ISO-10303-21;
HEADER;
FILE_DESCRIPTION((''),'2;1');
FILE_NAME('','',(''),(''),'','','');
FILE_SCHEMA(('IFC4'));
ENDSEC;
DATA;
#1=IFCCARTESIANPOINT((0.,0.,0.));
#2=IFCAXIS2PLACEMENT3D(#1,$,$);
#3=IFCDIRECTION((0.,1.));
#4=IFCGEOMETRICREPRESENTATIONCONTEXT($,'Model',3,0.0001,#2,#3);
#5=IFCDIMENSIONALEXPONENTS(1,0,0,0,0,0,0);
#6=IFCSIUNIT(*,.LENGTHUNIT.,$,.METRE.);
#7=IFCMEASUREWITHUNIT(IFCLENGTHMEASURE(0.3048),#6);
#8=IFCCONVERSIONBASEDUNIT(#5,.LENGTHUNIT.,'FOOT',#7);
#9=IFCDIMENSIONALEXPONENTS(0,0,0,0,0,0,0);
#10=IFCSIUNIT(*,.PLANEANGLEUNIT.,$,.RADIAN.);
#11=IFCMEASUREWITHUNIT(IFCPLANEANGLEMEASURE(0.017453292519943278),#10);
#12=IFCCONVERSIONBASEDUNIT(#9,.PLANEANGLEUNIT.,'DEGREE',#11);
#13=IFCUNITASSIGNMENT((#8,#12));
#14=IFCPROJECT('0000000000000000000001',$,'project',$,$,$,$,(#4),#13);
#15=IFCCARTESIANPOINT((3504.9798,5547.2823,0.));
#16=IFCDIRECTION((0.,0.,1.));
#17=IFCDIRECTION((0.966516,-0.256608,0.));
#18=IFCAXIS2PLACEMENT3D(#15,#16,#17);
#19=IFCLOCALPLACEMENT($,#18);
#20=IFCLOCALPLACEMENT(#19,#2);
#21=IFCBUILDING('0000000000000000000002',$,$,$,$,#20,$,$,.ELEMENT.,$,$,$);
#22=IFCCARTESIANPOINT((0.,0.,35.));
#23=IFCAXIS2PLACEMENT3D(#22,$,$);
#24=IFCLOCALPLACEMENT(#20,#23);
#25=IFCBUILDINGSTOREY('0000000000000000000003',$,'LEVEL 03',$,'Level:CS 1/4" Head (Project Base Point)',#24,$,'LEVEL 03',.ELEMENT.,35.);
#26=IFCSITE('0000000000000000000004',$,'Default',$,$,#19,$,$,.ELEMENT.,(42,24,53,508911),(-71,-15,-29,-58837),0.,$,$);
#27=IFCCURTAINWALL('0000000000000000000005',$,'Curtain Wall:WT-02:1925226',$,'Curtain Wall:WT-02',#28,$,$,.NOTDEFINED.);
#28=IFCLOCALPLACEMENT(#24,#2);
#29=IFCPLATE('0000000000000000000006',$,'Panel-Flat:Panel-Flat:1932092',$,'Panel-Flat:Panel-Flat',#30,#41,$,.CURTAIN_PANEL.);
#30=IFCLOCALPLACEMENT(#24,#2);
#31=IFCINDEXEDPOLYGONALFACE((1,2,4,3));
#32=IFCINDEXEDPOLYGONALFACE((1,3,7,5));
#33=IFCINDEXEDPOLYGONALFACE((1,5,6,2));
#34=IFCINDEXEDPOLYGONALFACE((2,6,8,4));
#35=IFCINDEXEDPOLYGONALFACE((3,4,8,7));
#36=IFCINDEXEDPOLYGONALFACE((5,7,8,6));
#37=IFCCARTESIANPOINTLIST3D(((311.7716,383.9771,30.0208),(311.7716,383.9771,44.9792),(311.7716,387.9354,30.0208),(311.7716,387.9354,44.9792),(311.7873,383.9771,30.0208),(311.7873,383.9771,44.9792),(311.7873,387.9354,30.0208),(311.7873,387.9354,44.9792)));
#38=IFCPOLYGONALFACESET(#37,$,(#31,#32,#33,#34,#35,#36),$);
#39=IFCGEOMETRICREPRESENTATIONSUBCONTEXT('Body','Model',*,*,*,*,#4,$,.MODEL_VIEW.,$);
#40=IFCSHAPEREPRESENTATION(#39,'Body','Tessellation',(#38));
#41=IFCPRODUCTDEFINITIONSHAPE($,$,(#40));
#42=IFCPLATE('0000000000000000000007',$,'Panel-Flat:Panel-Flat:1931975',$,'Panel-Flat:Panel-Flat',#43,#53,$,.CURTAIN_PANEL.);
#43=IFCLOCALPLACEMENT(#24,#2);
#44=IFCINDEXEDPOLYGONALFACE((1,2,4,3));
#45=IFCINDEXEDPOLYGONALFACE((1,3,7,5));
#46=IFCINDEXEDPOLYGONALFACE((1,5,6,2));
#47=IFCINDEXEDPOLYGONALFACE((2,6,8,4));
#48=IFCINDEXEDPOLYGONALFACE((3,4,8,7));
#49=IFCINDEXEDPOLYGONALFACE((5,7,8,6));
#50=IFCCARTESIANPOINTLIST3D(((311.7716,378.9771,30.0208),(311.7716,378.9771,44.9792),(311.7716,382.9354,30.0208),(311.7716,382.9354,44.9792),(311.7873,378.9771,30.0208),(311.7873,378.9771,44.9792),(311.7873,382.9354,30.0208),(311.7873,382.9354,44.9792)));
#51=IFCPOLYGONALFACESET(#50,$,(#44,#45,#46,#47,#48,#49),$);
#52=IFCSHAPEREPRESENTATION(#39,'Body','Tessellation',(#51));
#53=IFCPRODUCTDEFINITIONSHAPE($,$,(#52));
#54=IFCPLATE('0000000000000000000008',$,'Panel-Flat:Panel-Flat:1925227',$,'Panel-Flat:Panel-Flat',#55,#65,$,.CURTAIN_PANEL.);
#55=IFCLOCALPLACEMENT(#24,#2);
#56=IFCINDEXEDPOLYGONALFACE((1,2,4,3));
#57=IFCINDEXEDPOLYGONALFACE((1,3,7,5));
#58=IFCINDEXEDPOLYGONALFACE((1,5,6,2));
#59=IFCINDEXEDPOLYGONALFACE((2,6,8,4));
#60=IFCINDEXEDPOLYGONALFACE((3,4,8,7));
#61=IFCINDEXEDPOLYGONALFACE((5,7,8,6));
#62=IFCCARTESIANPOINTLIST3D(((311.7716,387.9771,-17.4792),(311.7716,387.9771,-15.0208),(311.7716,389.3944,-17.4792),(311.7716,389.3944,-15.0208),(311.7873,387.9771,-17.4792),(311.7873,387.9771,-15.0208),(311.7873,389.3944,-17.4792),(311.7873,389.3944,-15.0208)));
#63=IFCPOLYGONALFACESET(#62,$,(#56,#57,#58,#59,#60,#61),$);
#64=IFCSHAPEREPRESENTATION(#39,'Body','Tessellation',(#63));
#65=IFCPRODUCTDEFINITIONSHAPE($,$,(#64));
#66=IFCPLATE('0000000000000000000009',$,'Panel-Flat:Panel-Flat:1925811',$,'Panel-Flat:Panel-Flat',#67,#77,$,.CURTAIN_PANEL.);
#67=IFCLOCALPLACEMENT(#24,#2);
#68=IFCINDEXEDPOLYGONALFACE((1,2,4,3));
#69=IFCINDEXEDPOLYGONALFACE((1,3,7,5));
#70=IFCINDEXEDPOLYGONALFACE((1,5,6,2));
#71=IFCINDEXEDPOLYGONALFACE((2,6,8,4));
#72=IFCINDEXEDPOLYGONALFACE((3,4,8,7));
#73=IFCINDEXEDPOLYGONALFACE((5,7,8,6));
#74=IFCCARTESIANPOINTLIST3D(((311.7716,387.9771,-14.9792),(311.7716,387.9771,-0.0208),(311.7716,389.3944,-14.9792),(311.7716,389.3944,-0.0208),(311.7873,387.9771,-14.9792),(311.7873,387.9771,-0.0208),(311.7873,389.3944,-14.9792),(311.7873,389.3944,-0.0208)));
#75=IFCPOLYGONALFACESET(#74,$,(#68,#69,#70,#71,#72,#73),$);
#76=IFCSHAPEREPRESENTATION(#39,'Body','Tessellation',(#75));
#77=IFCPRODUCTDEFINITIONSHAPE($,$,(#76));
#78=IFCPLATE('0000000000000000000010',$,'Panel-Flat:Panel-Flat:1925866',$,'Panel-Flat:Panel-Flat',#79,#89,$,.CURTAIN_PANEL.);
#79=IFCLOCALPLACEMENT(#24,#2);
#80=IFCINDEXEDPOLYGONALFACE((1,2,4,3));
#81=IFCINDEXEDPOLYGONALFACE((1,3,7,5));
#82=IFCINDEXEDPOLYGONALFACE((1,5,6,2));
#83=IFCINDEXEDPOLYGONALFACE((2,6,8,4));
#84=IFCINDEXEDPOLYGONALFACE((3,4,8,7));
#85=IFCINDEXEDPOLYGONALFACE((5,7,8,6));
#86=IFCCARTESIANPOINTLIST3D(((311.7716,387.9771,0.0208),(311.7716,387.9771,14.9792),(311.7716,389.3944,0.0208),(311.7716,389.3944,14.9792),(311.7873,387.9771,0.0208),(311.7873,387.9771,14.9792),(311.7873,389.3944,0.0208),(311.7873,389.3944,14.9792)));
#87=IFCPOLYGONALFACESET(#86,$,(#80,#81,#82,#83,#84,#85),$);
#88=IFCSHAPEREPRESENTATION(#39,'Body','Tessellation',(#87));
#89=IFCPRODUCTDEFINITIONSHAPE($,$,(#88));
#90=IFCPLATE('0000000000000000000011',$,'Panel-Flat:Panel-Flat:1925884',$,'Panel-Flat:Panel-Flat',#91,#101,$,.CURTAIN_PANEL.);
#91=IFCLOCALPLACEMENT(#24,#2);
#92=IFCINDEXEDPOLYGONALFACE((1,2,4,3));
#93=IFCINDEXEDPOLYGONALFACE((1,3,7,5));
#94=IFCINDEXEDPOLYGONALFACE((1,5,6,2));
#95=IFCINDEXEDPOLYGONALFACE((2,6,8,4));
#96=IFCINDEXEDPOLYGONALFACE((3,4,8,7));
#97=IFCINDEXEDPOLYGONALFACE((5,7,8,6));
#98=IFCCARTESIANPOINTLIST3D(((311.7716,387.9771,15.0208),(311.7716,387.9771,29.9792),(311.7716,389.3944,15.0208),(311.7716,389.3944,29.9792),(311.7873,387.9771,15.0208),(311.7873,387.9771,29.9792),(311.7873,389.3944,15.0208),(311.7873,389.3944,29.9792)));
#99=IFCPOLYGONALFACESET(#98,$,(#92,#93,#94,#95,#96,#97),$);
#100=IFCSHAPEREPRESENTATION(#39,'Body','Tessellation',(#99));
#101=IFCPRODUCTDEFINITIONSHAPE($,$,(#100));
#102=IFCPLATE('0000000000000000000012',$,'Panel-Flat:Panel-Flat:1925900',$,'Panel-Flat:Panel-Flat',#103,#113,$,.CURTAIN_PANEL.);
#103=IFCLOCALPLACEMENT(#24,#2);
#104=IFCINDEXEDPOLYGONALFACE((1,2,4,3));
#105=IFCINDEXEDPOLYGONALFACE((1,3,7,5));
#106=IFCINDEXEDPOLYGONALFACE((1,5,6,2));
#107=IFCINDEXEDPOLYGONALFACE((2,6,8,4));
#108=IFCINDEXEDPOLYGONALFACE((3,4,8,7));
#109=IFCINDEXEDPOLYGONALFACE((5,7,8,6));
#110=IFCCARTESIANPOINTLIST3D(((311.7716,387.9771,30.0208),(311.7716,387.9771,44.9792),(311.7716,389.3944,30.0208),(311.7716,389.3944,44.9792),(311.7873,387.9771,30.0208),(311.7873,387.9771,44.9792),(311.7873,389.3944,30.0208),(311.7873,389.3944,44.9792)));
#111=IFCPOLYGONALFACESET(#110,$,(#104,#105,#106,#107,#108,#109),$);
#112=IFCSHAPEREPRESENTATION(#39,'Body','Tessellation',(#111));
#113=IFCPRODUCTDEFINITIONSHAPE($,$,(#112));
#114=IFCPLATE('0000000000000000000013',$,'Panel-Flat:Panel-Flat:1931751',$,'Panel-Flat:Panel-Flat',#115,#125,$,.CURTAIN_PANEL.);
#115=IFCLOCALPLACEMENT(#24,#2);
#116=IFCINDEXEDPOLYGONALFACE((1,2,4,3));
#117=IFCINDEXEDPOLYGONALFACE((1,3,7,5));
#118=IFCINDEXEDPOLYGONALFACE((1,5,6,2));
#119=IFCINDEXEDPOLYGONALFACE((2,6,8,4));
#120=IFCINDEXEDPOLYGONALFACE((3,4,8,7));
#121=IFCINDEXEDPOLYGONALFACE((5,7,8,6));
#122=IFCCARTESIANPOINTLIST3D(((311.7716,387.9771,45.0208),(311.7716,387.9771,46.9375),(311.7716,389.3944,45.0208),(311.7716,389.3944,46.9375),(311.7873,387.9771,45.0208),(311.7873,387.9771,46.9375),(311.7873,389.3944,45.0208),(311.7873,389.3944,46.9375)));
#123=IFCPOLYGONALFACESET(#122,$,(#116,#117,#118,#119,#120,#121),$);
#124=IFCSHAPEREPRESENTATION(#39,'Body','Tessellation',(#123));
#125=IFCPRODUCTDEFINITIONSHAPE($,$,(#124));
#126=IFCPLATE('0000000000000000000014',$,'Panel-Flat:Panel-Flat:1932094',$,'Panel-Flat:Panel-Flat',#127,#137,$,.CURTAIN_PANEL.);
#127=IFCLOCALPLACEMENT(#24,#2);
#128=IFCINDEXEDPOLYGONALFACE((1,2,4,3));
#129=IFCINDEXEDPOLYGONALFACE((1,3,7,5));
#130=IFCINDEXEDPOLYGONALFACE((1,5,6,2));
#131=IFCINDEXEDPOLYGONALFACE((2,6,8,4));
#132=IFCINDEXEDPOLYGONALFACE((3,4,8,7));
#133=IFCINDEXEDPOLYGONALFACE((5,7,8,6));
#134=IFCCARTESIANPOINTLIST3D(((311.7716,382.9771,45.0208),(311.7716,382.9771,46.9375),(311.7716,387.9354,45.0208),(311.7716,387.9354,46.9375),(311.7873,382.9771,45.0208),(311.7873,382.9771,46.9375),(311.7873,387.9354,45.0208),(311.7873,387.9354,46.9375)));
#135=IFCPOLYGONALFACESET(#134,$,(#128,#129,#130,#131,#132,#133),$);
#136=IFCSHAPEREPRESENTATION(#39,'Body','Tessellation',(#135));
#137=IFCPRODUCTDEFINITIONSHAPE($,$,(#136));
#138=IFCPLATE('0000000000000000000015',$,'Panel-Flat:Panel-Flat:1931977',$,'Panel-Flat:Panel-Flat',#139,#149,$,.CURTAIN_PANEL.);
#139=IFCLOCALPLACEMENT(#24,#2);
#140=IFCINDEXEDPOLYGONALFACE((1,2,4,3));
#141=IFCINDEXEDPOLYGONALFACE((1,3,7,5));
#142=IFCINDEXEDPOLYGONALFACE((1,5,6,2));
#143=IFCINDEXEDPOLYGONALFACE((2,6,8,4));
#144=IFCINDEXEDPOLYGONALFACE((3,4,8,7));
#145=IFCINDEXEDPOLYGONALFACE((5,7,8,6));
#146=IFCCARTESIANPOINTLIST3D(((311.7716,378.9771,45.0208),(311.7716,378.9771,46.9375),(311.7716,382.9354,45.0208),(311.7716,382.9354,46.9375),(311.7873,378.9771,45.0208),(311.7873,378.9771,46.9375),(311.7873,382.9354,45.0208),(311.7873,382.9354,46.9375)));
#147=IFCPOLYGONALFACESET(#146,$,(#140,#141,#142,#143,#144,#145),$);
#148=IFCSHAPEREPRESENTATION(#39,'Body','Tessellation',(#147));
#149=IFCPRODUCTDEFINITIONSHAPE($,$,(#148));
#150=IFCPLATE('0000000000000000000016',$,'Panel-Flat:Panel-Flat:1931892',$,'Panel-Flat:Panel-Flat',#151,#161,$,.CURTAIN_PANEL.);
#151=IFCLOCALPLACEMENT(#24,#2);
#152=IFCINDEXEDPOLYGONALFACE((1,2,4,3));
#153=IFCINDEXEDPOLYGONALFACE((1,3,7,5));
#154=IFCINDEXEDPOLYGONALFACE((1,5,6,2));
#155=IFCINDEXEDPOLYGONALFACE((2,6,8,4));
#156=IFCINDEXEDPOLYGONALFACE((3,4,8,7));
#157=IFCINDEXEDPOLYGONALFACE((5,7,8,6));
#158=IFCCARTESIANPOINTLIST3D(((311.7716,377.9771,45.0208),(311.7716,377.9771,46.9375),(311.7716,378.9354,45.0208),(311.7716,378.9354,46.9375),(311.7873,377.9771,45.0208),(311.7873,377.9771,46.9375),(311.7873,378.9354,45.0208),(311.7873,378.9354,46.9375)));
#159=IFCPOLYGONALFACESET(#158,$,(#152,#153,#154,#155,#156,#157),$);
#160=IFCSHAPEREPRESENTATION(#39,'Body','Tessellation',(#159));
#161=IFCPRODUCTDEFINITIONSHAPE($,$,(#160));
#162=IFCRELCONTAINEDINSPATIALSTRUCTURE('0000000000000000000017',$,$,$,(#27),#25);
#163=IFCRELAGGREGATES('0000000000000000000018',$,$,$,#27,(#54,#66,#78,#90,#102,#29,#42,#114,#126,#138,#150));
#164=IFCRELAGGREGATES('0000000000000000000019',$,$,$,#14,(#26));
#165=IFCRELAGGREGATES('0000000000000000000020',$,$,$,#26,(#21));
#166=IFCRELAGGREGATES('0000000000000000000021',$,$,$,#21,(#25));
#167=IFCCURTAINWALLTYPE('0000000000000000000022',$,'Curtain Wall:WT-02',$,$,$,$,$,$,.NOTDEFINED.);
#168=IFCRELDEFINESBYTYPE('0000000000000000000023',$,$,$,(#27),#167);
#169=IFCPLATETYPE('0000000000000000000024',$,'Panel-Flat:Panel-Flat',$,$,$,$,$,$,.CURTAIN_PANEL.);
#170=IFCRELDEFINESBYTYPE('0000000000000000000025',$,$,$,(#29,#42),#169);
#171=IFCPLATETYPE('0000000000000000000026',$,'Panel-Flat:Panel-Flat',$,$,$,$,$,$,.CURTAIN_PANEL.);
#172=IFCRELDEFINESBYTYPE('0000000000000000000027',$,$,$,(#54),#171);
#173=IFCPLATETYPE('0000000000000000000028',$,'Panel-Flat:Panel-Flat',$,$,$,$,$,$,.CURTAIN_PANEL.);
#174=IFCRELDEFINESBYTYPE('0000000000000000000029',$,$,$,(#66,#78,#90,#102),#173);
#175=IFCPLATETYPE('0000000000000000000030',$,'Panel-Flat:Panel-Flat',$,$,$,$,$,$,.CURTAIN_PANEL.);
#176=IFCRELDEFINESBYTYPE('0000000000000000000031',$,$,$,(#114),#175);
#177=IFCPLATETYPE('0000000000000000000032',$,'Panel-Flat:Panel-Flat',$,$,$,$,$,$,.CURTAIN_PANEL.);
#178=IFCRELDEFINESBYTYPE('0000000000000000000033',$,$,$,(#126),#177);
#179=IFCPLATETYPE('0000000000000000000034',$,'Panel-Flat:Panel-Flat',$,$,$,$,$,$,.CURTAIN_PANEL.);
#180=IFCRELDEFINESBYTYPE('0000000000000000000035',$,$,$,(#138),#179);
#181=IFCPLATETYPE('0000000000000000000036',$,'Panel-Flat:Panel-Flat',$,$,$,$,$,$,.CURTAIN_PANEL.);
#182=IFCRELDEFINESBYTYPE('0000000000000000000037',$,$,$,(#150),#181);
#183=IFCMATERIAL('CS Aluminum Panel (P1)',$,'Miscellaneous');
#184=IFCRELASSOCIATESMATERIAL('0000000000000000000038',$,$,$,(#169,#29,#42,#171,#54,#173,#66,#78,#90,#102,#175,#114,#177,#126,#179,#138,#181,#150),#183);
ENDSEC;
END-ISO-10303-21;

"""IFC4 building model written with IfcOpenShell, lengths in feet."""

from ifc_helpers import new_model, entity, si_unit, converted_unit, direction, frame, origin, place, context, subcontext, project, spatial, indexed_curve, outline, extrude, source, transform, mapped, material, type_object, type_shapes, element, aggregate, save


model = new_model("IFC4")

# Units and contexts
model_context = context("Model", 3, precision=0.0001, world=origin(), true_north=direction((0.0, 1.0)))
body_context = subcontext(model_context, "Body", "Model", "MODEL_VIEW")
ifc_project = project(units=[converted_unit("LENGTHUNIT", "FOOT", entity("IfcLengthMeasure", 0.3048), si_unit("LENGTHUNIT", "METRE"), dimensions=[1, 0, 0, 0, 0, 0, 0]), converted_unit("PLANEANGLEUNIT", "DEGREE", entity("IfcPlaneAngleMeasure", 0.017453292519943278), si_unit("PLANEANGLEUNIT", "RADIAN"), dimensions=[0, 0, 0, 0, 0, 0, 0])], contexts=[model_context])

# Site, building, storey
site_placement = place(None, frame((3504.9798, 5547.2823, 0.0), z_axis=(0.0, 0.0, 1.0), x_axis=(0.966516, -0.256608, 0.0)))
site = spatial("IfcSite", under=ifc_project, at=site_placement, Name="Default", CompositionType="ELEMENT", RefLatitude=(42, 24, 53, 508911), RefLongitude=(-71, -15, -29, -58837), RefElevation=0.0)
building_placement = place(site_placement, origin())
building = spatial("IfcBuilding", under=site, at=building_placement, CompositionType="ELEMENT")
storey_placement = place(building_placement, frame((0.0, 0.0, 35.0)))
storey = spatial("IfcBuildingStorey", under=building, at=storey_placement, Name="LEVEL 03", ObjectType="Level:CS 1/4\" Head (Project Base Point)", LongName="LEVEL 03", CompositionType="ELEMENT", Elevation=35.0)

# Curtain wall, plates
curtain_wall_type = type_object("IfcCurtainWallType", Name="Curtain Wall:WT-02", PredefinedType="NOTDEFINED")
curtain_wall_1_placement = place(storey_placement, frame((0.0, 0.0, -35.0)))
curtain_wall_1 = element("IfcCurtainWall", 1, at=curtain_wall_1_placement, inside=storey, type_object=curtain_wall_type, Name="Curtain Wall:WT-02:1925226", ObjectType="Curtain Wall:WT-02", PredefinedType="NOTDEFINED")
ifc_material_1 = material(Name="CS Aluminum Panel (P1)", Category="Miscellaneous")
plate_type_1 = type_object("IfcPlateType", Name="Panel-Flat:Panel-Flat", PredefinedType="CURTAIN_PANEL", material=ifc_material_1)
shared_shape_1 = source(origin(), body_context, "Body", "SweptSolid", [
    extrude(outline(indexed_curve([(-0.0078, -1.9792), (0.0078, -1.9792), (0.0078, 1.9792), (-0.0078, 1.9792), (-0.0078, -1.9792)], self_intersect=False)), frame((0.0, -0.0078, 0.0208), z_axis=(0.0, 0.0, 1.0), x_axis=(0.0, -1.0, 0.0)), (0.0, 0.0, 1.0), 14.9583),
])
type_shapes(plate_type_1, [shared_shape_1])
plate_1_placement = place(curtain_wall_1_placement, frame((311.7873, 385.9563, 65.0), z_axis=(0.0, 0.0, 1.0), x_axis=(0.0, -1.0, 0.0)))
plate_1 = element("IfcPlate", 2, at=plate_1_placement, type_object=plate_type_1, material=ifc_material_1, Name="Panel-Flat:Panel-Flat:1932092", ObjectType="Panel-Flat:Panel-Flat", PredefinedType="CURTAIN_PANEL", context=body_context, shape_type="MappedRepresentation", body=[
    mapped(shared_shape_1, transform((0.0, 0.0, 0.0), scale=1.0)),
])
plate_2_placement = place(curtain_wall_1_placement, frame((311.7873, 380.9563, 65.0), z_axis=(0.0, 0.0, 1.0), x_axis=(0.0, -1.0, 0.0)))
plate_2 = element("IfcPlate", 3, at=plate_2_placement, type_object=plate_type_1, material=ifc_material_1, Name="Panel-Flat:Panel-Flat:1931975", ObjectType="Panel-Flat:Panel-Flat", PredefinedType="CURTAIN_PANEL", context=body_context, shape_type="MappedRepresentation", body=[
    mapped(shared_shape_1, transform((0.0, 0.0, 0.0), scale=1.0)),
])
plate_type_2 = type_object("IfcPlateType", Name="Panel-Flat:Panel-Flat", PredefinedType="CURTAIN_PANEL", material=ifc_material_1)
shared_shape_2 = source(origin(), body_context, "Body", "SweptSolid", [
    extrude(outline(indexed_curve([(-0.0078, -0.7087), (0.0078, -0.7087), (0.0078, 0.7087), (-0.0078, 0.7087), (-0.0078, -0.7087)], self_intersect=False)), frame((0.0, -0.0078, 0.0208), z_axis=(0.0, 0.0, 1.0), x_axis=(0.0, -1.0, 0.0)), (0.0, 0.0, 1.0), 2.4583),
])
type_shapes(plate_type_2, [shared_shape_2])
plate_3_placement = place(curtain_wall_1_placement, frame((311.7873, 388.6858, 17.5), z_axis=(0.0, 0.0, 1.0), x_axis=(0.0, -1.0, 0.0)))
plate_3 = element("IfcPlate", 4, at=plate_3_placement, type_object=plate_type_2, material=ifc_material_1, Name="Panel-Flat:Panel-Flat:1925227", ObjectType="Panel-Flat:Panel-Flat", PredefinedType="CURTAIN_PANEL", context=body_context, shape_type="MappedRepresentation", body=[
    mapped(shared_shape_2, transform((0.0, 0.0, 0.0), scale=1.0)),
])
plate_type_3 = type_object("IfcPlateType", Name="Panel-Flat:Panel-Flat", PredefinedType="CURTAIN_PANEL", material=ifc_material_1)
shared_shape_3 = source(origin(), body_context, "Body", "SweptSolid", [
    extrude(outline(indexed_curve([(-0.0078, -0.7087), (0.0078, -0.7087), (0.0078, 0.7087), (-0.0078, 0.7087), (-0.0078, -0.7087)], self_intersect=False)), frame((0.0, -0.0078, 0.0208), z_axis=(0.0, 0.0, 1.0), x_axis=(0.0, -1.0, 0.0)), (0.0, 0.0, 1.0), 14.9583),
])
type_shapes(plate_type_3, [shared_shape_3])
plate_4_placement = place(curtain_wall_1_placement, frame((311.7873, 388.6858, 20.0), z_axis=(0.0, 0.0, 1.0), x_axis=(0.0, -1.0, 0.0)))
plate_4 = element("IfcPlate", 5, at=plate_4_placement, type_object=plate_type_3, material=ifc_material_1, Name="Panel-Flat:Panel-Flat:1925811", ObjectType="Panel-Flat:Panel-Flat", PredefinedType="CURTAIN_PANEL", context=body_context, shape_type="MappedRepresentation", body=[
    mapped(shared_shape_3, transform((0.0, 0.0, 0.0), scale=1.0)),
])
plate_5_placement = place(curtain_wall_1_placement, frame((311.7873, 388.6858, 35.0), z_axis=(0.0, 0.0, 1.0), x_axis=(0.0, -1.0, 0.0)))
plate_5 = element("IfcPlate", 6, at=plate_5_placement, type_object=plate_type_3, material=ifc_material_1, Name="Panel-Flat:Panel-Flat:1925866", ObjectType="Panel-Flat:Panel-Flat", PredefinedType="CURTAIN_PANEL", context=body_context, shape_type="MappedRepresentation", body=[
    mapped(shared_shape_3, transform((0.0, 0.0, 0.0), scale=1.0)),
])
plate_6_placement = place(curtain_wall_1_placement, frame((311.7873, 388.6858, 50.0), z_axis=(0.0, 0.0, 1.0), x_axis=(0.0, -1.0, 0.0)))
plate_6 = element("IfcPlate", 7, at=plate_6_placement, type_object=plate_type_3, material=ifc_material_1, Name="Panel-Flat:Panel-Flat:1925884", ObjectType="Panel-Flat:Panel-Flat", PredefinedType="CURTAIN_PANEL", context=body_context, shape_type="MappedRepresentation", body=[
    mapped(shared_shape_3, transform((0.0, 0.0, 0.0), scale=1.0)),
])
plate_7_placement = place(curtain_wall_1_placement, frame((311.7873, 388.6858, 65.0), z_axis=(0.0, 0.0, 1.0), x_axis=(0.0, -1.0, 0.0)))
plate_7 = element("IfcPlate", 8, at=plate_7_placement, type_object=plate_type_3, material=ifc_material_1, Name="Panel-Flat:Panel-Flat:1925900", ObjectType="Panel-Flat:Panel-Flat", PredefinedType="CURTAIN_PANEL", context=body_context, shape_type="MappedRepresentation", body=[
    mapped(shared_shape_3, transform((0.0, 0.0, 0.0), scale=1.0)),
])
plate_type_4 = type_object("IfcPlateType", Name="Panel-Flat:Panel-Flat", PredefinedType="CURTAIN_PANEL", material=ifc_material_1)
shared_shape_4 = source(origin(), body_context, "Body", "SweptSolid", [
    extrude(outline(indexed_curve([(-0.0078, -0.7087), (0.0078, -0.7087), (0.0078, 0.7087), (-0.0078, 0.7087), (-0.0078, -0.7087)], self_intersect=False)), frame((0.0, -0.0078, 0.0208), z_axis=(0.0, 0.0, 1.0), x_axis=(0.0, -1.0, 0.0)), (0.0, 0.0, 1.0), 1.9167),
])
type_shapes(plate_type_4, [shared_shape_4])
plate_8_placement = place(curtain_wall_1_placement, frame((311.7873, 388.6858, 80.0), z_axis=(0.0, 0.0, 1.0), x_axis=(0.0, -1.0, 0.0)))
plate_8 = element("IfcPlate", 9, at=plate_8_placement, type_object=plate_type_4, material=ifc_material_1, Name="Panel-Flat:Panel-Flat:1931751", ObjectType="Panel-Flat:Panel-Flat", PredefinedType="CURTAIN_PANEL", context=body_context, shape_type="MappedRepresentation", body=[
    mapped(shared_shape_4, transform((0.0, 0.0, 0.0), scale=1.0)),
])
plate_type_5 = type_object("IfcPlateType", Name="Panel-Flat:Panel-Flat", PredefinedType="CURTAIN_PANEL", material=ifc_material_1)
shared_shape_5 = source(origin(), body_context, "Body", "SweptSolid", [
    extrude(outline(indexed_curve([(-0.0078, -2.4792), (0.0078, -2.4792), (0.0078, 2.4792), (-0.0078, 2.4792), (-0.0078, -2.4792)], self_intersect=False)), frame((0.0, -0.0078, 0.0208), z_axis=(0.0, 0.0, 1.0), x_axis=(0.0, -1.0, 0.0)), (0.0, 0.0, 1.0), 1.9167),
])
type_shapes(plate_type_5, [shared_shape_5])
plate_9_placement = place(curtain_wall_1_placement, frame((311.7873, 385.4563, 80.0), z_axis=(0.0, 0.0, 1.0), x_axis=(0.0, -1.0, 0.0)))
plate_9 = element("IfcPlate", 10, at=plate_9_placement, type_object=plate_type_5, material=ifc_material_1, Name="Panel-Flat:Panel-Flat:1932094", ObjectType="Panel-Flat:Panel-Flat", PredefinedType="CURTAIN_PANEL", context=body_context, shape_type="MappedRepresentation", body=[
    mapped(shared_shape_5, transform((0.0, 0.0, 0.0), scale=1.0)),
])
plate_type_6 = type_object("IfcPlateType", Name="Panel-Flat:Panel-Flat", PredefinedType="CURTAIN_PANEL", material=ifc_material_1)
shared_shape_6 = source(origin(), body_context, "Body", "SweptSolid", [
    extrude(outline(indexed_curve([(-0.0078, -1.9792), (0.0078, -1.9792), (0.0078, 1.9792), (-0.0078, 1.9792), (-0.0078, -1.9792)], self_intersect=False)), frame((0.0, -0.0078, 0.0208), z_axis=(0.0, 0.0, 1.0), x_axis=(0.0, -1.0, 0.0)), (0.0, 0.0, 1.0), 1.9167),
])
type_shapes(plate_type_6, [shared_shape_6])
plate_10_placement = place(curtain_wall_1_placement, frame((311.7873, 380.9563, 80.0), z_axis=(0.0, 0.0, 1.0), x_axis=(0.0, -1.0, 0.0)))
plate_10 = element("IfcPlate", 11, at=plate_10_placement, type_object=plate_type_6, material=ifc_material_1, Name="Panel-Flat:Panel-Flat:1931977", ObjectType="Panel-Flat:Panel-Flat", PredefinedType="CURTAIN_PANEL", context=body_context, shape_type="MappedRepresentation", body=[
    mapped(shared_shape_6, transform((0.0, 0.0, 0.0), scale=1.0)),
])
plate_type_7 = type_object("IfcPlateType", Name="Panel-Flat:Panel-Flat", PredefinedType="CURTAIN_PANEL", material=ifc_material_1)
shared_shape_7 = source(origin(), body_context, "Body", "SweptSolid", [
    extrude(outline(indexed_curve([(-0.0078, -0.4792), (0.0078, -0.4792), (0.0078, 0.4792), (-0.0078, 0.4792), (-0.0078, -0.4792)], self_intersect=False)), frame((0.0, -0.0078, 0.0208), z_axis=(0.0, 0.0, 1.0), x_axis=(0.0, -1.0, 0.0)), (0.0, 0.0, 1.0), 1.9167),
])
type_shapes(plate_type_7, [shared_shape_7])
plate_11_placement = place(curtain_wall_1_placement, frame((311.7873, 378.4563, 80.0), z_axis=(0.0, 0.0, 1.0), x_axis=(0.0, -1.0, 0.0)))
plate_11 = element("IfcPlate", 12, at=plate_11_placement, type_object=plate_type_7, material=ifc_material_1, Name="Panel-Flat:Panel-Flat:1931892", ObjectType="Panel-Flat:Panel-Flat", PredefinedType="CURTAIN_PANEL", context=body_context, shape_type="MappedRepresentation", body=[
    mapped(shared_shape_7, transform((0.0, 0.0, 0.0), scale=1.0)),
])
aggregate(curtain_wall_1, [plate_3, plate_4, plate_5, plate_6, plate_7, plate_1, plate_2, plate_8, plate_9, plate_10, plate_11])

save(model, "model.ifc")
